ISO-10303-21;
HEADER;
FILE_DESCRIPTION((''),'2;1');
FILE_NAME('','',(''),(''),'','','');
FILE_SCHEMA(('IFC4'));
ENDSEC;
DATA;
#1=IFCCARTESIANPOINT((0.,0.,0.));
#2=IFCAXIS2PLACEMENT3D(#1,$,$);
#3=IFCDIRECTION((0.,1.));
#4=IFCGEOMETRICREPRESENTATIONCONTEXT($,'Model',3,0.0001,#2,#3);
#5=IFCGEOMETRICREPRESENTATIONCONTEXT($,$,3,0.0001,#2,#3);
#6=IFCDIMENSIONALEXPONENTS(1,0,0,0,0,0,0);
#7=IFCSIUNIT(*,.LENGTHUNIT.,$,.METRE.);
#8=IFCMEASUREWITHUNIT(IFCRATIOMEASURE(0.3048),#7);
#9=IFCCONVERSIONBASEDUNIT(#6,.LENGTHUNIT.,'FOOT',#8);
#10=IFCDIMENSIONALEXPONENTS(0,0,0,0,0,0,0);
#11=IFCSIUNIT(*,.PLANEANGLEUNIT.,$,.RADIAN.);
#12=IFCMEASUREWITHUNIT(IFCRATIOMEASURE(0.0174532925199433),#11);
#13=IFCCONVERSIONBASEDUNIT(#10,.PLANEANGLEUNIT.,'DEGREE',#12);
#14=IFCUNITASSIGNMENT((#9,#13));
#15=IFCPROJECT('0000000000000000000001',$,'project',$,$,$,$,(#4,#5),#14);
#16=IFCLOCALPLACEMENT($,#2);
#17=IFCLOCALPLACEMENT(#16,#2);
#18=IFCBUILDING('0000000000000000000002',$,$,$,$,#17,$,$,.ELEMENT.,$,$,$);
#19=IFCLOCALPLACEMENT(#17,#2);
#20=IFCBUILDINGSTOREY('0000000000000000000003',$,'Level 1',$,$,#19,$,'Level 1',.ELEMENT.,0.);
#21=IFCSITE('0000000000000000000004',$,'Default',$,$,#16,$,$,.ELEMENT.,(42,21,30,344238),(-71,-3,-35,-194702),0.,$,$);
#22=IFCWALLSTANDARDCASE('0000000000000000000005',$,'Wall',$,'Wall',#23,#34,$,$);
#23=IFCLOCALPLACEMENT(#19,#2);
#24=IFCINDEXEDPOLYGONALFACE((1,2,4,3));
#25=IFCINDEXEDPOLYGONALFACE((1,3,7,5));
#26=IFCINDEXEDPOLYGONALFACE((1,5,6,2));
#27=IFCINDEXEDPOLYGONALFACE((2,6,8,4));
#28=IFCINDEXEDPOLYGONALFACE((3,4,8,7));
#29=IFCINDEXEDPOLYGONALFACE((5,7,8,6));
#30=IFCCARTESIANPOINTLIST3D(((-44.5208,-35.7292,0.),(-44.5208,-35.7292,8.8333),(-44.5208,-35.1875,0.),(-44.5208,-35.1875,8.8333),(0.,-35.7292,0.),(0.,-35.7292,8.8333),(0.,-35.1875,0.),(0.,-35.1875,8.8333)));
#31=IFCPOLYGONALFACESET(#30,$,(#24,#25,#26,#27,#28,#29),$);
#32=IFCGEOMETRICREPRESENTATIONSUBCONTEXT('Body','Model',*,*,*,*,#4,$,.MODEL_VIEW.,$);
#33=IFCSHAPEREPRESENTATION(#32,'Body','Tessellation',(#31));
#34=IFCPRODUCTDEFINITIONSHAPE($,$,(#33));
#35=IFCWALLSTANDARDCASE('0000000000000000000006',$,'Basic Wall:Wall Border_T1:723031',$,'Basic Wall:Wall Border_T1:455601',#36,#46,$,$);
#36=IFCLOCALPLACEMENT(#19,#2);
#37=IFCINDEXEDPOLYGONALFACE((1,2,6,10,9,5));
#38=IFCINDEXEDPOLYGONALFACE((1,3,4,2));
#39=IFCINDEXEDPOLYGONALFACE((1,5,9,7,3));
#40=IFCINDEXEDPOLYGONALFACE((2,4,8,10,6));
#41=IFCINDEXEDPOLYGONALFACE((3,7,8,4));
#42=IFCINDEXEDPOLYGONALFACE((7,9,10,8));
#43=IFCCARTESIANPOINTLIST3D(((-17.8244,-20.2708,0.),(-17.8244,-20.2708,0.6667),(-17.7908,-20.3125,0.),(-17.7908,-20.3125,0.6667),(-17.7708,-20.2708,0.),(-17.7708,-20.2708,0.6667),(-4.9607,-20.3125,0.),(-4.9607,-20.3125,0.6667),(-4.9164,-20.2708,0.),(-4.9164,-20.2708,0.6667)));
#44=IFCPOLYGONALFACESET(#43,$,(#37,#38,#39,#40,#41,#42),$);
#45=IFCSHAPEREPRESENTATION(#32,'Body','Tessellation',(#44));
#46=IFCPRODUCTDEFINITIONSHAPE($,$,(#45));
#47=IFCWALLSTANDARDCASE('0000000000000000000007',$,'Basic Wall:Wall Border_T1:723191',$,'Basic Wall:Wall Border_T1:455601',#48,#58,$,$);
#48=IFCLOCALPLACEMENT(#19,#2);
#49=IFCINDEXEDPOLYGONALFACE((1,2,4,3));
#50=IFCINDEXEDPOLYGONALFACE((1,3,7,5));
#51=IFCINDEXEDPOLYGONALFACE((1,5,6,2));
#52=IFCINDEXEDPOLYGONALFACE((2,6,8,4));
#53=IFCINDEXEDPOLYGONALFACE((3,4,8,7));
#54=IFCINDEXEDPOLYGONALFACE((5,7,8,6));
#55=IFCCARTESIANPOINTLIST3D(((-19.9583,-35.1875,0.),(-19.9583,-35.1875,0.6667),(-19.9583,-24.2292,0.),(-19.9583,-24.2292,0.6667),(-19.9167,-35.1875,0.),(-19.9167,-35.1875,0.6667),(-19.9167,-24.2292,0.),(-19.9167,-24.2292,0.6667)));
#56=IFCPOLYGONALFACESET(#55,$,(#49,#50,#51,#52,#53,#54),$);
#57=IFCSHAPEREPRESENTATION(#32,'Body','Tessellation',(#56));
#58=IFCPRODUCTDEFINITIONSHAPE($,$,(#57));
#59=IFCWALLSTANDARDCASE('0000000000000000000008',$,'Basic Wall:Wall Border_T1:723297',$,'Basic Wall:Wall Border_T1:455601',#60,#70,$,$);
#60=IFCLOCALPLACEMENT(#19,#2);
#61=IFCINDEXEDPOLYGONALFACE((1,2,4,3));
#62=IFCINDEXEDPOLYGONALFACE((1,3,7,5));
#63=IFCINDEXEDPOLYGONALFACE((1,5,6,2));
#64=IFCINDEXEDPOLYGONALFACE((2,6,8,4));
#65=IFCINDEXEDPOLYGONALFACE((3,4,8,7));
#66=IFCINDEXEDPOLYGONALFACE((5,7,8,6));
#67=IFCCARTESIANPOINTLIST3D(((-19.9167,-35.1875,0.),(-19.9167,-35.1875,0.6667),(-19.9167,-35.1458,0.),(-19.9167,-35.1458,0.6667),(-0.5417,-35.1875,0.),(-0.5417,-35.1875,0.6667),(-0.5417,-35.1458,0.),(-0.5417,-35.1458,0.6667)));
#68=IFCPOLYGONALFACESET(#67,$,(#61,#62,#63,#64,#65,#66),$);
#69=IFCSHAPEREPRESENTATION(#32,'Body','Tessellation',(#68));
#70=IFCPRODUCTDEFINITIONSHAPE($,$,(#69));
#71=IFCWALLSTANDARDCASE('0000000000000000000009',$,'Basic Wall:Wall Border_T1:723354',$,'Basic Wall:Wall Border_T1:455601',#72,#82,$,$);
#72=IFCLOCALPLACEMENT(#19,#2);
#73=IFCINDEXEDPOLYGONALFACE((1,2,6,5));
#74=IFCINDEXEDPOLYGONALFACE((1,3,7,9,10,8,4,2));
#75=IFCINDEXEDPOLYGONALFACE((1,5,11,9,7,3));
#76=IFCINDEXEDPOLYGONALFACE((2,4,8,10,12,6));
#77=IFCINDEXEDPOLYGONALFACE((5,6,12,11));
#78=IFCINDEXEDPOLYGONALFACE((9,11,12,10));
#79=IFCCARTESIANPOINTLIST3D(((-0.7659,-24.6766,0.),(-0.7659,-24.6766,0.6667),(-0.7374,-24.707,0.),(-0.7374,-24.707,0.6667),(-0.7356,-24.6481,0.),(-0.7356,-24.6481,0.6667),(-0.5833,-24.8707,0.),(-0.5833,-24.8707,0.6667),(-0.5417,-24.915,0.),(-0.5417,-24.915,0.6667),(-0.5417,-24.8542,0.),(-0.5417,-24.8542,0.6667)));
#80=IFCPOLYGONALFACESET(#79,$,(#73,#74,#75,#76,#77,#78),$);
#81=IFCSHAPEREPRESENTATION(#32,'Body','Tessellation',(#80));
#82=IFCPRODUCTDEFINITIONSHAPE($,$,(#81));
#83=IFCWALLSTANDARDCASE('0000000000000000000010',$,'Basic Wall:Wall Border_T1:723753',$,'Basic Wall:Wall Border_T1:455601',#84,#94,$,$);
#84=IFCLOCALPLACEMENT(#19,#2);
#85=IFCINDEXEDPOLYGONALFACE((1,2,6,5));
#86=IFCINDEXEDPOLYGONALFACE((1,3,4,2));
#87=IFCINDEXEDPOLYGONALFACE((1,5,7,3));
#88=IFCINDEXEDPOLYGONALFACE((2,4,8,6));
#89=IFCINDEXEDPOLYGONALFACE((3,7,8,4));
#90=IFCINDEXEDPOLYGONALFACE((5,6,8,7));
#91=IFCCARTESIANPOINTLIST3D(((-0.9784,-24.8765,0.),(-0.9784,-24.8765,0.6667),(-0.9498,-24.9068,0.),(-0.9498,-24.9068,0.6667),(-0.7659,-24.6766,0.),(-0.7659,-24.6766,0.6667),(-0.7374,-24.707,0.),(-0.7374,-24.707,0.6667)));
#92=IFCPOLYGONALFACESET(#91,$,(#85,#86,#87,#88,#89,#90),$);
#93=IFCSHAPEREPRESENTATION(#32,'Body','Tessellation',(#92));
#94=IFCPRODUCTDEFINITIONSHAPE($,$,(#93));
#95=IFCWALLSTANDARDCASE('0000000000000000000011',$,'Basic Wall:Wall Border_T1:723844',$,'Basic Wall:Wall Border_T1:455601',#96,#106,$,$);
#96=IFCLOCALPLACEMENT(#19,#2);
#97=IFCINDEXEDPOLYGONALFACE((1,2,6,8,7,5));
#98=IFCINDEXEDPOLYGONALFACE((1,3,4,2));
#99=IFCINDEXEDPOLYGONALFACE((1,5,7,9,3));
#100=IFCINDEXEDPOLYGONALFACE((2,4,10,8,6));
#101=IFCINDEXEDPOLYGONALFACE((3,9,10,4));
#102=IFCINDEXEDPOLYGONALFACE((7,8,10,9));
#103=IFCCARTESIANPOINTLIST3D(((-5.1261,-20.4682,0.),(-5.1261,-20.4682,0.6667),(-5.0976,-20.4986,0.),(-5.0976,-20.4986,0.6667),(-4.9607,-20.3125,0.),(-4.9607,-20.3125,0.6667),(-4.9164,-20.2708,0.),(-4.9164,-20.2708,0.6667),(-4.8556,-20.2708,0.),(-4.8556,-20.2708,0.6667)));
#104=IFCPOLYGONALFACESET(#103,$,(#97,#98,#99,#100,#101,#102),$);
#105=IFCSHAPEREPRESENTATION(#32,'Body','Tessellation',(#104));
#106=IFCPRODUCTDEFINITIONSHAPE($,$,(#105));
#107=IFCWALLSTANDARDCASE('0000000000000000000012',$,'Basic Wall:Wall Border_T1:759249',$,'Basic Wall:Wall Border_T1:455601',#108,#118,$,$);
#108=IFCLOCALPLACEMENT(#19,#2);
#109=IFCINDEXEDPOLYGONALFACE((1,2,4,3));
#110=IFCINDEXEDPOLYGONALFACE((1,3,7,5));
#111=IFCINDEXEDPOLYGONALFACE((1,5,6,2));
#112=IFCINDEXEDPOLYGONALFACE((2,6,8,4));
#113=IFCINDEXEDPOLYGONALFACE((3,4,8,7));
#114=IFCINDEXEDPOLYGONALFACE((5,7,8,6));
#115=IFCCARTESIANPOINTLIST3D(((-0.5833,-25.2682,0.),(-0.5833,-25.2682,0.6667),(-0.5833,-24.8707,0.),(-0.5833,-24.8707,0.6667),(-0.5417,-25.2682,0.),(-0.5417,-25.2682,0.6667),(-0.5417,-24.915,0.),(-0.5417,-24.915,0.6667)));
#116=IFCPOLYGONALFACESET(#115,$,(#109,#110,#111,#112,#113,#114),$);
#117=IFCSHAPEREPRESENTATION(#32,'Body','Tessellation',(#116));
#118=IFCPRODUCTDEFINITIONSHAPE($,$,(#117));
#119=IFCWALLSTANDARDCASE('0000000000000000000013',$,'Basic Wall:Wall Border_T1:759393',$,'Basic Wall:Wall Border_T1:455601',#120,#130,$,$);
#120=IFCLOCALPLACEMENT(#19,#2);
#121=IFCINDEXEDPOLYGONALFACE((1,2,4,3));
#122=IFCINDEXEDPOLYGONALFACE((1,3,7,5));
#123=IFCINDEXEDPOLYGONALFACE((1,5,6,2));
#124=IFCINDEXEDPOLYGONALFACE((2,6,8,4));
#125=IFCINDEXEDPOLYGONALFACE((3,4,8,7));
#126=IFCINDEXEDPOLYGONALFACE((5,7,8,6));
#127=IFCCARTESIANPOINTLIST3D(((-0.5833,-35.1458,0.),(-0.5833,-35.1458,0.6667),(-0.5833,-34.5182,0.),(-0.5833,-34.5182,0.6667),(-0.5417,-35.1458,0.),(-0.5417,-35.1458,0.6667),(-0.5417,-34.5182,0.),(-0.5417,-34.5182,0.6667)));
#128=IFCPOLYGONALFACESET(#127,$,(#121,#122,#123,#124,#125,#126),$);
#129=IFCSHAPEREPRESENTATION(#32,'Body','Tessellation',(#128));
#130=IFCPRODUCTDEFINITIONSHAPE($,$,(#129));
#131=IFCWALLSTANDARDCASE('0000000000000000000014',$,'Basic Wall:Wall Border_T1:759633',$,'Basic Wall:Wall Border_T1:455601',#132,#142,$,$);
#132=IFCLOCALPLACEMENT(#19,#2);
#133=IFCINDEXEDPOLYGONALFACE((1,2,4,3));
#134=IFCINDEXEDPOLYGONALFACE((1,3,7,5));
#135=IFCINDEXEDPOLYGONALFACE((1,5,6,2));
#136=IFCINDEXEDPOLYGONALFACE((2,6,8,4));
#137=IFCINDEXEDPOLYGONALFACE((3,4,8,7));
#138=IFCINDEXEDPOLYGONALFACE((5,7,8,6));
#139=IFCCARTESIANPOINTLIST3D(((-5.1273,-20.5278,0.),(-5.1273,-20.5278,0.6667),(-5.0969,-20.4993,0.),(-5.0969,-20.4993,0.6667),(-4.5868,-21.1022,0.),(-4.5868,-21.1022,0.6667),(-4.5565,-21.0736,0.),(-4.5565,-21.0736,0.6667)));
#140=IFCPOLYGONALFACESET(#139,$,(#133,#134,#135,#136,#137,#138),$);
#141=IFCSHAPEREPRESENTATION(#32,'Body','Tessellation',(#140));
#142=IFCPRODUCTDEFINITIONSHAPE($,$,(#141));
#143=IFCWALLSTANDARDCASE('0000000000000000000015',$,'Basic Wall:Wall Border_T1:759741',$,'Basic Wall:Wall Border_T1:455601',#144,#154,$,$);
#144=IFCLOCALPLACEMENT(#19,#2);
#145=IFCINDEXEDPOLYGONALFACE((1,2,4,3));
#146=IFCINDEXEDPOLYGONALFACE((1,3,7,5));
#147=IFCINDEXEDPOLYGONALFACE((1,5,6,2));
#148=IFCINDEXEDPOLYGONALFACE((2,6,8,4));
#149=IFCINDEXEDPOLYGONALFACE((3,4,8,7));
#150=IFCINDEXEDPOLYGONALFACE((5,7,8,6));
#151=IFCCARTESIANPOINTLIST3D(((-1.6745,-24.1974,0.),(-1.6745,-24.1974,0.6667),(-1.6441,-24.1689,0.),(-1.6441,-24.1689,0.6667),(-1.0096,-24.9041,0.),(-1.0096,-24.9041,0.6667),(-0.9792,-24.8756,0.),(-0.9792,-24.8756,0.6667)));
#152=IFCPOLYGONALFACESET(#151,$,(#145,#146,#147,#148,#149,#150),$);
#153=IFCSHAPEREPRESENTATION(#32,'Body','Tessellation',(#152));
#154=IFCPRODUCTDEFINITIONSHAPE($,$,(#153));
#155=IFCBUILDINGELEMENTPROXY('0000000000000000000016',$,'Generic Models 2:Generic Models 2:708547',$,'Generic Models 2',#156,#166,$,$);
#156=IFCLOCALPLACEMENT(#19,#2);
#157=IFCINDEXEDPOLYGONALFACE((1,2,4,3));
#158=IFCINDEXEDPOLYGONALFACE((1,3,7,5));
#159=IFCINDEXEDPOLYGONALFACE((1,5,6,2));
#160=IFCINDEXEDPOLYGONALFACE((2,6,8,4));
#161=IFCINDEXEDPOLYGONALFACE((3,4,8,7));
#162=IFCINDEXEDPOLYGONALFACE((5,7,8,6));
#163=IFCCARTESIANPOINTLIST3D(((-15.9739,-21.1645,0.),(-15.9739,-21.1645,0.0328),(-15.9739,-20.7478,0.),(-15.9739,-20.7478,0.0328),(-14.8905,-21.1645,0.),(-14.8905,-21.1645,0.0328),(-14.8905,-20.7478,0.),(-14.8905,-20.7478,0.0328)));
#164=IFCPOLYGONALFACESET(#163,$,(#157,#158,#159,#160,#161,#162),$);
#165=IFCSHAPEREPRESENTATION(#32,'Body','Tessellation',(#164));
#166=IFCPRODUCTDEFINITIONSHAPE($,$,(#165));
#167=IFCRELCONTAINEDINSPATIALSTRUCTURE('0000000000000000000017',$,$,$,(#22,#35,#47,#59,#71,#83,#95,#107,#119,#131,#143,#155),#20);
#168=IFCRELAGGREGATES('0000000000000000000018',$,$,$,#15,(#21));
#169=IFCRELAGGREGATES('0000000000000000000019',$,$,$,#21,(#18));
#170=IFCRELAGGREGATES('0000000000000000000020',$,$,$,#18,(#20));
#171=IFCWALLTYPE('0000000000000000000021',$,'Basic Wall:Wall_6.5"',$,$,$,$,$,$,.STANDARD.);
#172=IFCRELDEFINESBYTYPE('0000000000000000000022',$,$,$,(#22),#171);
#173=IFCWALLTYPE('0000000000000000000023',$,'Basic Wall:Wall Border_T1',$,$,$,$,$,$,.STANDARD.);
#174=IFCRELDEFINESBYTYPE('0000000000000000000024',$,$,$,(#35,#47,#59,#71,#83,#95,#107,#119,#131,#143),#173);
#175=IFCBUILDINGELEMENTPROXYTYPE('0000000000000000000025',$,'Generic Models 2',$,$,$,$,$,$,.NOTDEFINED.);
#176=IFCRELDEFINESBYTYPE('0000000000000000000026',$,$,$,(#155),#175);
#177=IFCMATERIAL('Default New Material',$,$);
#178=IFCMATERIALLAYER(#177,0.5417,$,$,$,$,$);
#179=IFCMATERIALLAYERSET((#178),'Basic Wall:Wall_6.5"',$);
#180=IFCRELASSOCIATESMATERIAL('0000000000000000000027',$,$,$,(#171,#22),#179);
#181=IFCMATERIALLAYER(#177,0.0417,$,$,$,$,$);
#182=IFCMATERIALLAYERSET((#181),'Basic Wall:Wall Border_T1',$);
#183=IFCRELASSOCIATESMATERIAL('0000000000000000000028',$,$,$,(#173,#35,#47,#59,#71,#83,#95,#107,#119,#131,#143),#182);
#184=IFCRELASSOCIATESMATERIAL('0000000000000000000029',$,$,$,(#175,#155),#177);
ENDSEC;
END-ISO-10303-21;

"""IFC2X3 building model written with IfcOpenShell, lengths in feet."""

from ifc_helpers import new_model, entity, si_unit, converted_unit, direction, frame, frame_2d, origin, place, context, subcontext, project, spatial, polyline, rectangle, outline, extrude, source, transform, mapped, material, layer, layer_set, layer_usage, type_object, type_shapes, element, save


model = new_model("IFC2X3")

# Units and contexts
model_context = context("Model", 3, precision=0.0001, world=origin(), true_north=direction((0.0, 1.0)))
context_of_model = context(None, 3, precision=0.0001, world=origin(), true_north=direction((0.0, 1.0)))
body_context = subcontext(model_context, "Body", "Model", "MODEL_VIEW")
ifc_project = project(units=[converted_unit("LENGTHUNIT", "FOOT", entity("IfcRatioMeasure", 0.3048), si_unit("LENGTHUNIT", "METRE"), dimensions=[1, 0, 0, 0, 0, 0, 0]), converted_unit("PLANEANGLEUNIT", "DEGREE", entity("IfcRatioMeasure", 0.0174532925199433), si_unit("PLANEANGLEUNIT", "RADIAN"), dimensions=[0, 0, 0, 0, 0, 0, 0])], contexts=[model_context, context_of_model])

# Site, building, storey
site_placement = place(None, origin())
site = spatial("IfcSite", under=ifc_project, at=site_placement, Name="Default", CompositionType="ELEMENT", RefLatitude=(42, 21, 30, 344238), RefLongitude=(-71, -3, -35, -194702), RefElevation=0.0)
building_placement = place(site_placement, origin())
building = spatial("IfcBuilding", under=site, at=building_placement, CompositionType="ELEMENT")
storey_placement = place(building_placement, origin())
storey = spatial("IfcBuildingStorey", under=building, at=storey_placement, Name="Level 1", LongName="Level 1", CompositionType="ELEMENT", Elevation=0.0)

# Wall
ifc_material_1 = material(Name="Default New Material")
ifc_layer_1 = layer(ifc_material_1, 0.5417)
ifc_layer_set_1 = layer_set([ifc_layer_1], Name="Basic Wall:Wall_6.5\"")
ifc_layer_usage_1 = layer_usage(ifc_layer_set_1, "AXIS2", "NEGATIVE", 0.2708)
wall_type_1 = type_object("IfcWallType", Name="Basic Wall:Wall_6.5\"", PredefinedType="STANDARD", material=ifc_layer_set_1)
wall_1_placement = place(storey_placement, frame((0.0, -35.4583, 0.0), z_axis=(0.0, 0.0, 1.0), x_axis=(-1.0, 0.0, 0.0)))
element("IfcWallStandardCase", 1, at=wall_1_placement, inside=storey, type_object=wall_type_1, material=ifc_layer_usage_1, Name="Wall", ObjectType="Wall", context=body_context, shape_type="SweptSolid", body=[
    extrude(rectangle(XDim=44.5208, YDim=0.5417, at=frame_2d((22.2604, 0.0), x_axis=(-1.0, 0.0))), origin(), (0.0, 0.0, 1.0), 8.8333),
])

# Walls
ifc_layer_2 = layer(ifc_material_1, 0.0417)
ifc_layer_set_2 = layer_set([ifc_layer_2], Name="Basic Wall:Wall Border_T1")
ifc_layer_usage_2 = layer_usage(ifc_layer_set_2, "AXIS2", "NEGATIVE", 0.0208)
wall_type_2 = type_object("IfcWallType", Name="Basic Wall:Wall Border_T1", PredefinedType="STANDARD", material=ifc_layer_set_2)
wall_2_placement = place(storey_placement, frame((-4.9164, -20.2917, 0.0), z_axis=(0.0, 0.0, 1.0), x_axis=(-1.0, 0.0, 0.0)))
element("IfcWallStandardCase", 2, at=wall_2_placement, inside=storey, type_object=wall_type_2, material=ifc_layer_usage_2, Name="Basic Wall:Wall Border_T1:723031", ObjectType="Basic Wall:Wall Border_T1:455601", context=body_context, shape_type="SweptSolid", body=[
    extrude(outline(polyline([(12.908, -0.0208), (12.8744, 0.0208), (0.0443, 0.0208), (0.0, -0.0208), (12.8545, -0.0208), (12.908, -0.0208)])), origin(), (0.0, 0.0, 1.0), 0.6667),
])
ifc_layer_usage_3 = layer_usage(ifc_layer_set_2, "AXIS2", "NEGATIVE", 0.0208)
wall_3_placement = place(storey_placement, frame((-19.9375, -24.2292, 0.0), z_axis=(0.0, 0.0, 1.0), x_axis=(0.0, -1.0, 0.0)))
element("IfcWallStandardCase", 3, at=wall_3_placement, inside=storey, type_object=wall_type_2, material=ifc_layer_usage_3, Name="Basic Wall:Wall Border_T1:723191", ObjectType="Basic Wall:Wall Border_T1:455601", context=body_context, shape_type="SweptSolid", body=[
    extrude(rectangle(XDim=10.9583, YDim=0.0417, at=frame_2d((5.4792, 0.0), x_axis=(-1.0, 0.0))), origin(), (0.0, 0.0, 1.0), 0.6667),
])
ifc_layer_usage_4 = layer_usage(ifc_layer_set_2, "AXIS2", "NEGATIVE", 0.0208)
wall_4_placement = place(storey_placement, frame((-19.9167, -35.1667, 0.0)))
element("IfcWallStandardCase", 4, at=wall_4_placement, inside=storey, type_object=wall_type_2, material=ifc_layer_usage_4, Name="Basic Wall:Wall Border_T1:723297", ObjectType="Basic Wall:Wall Border_T1:455601", context=body_context, shape_type="SweptSolid", body=[
    extrude(rectangle(XDim=19.375, YDim=0.0417, at=frame_2d((9.6875, 0.0), x_axis=(-1.0, 0.0))), origin(), (0.0, 0.0, 1.0), 0.6667),
])
ifc_layer_usage_5 = layer_usage(ifc_layer_set_2, "AXIS2", "POSITIVE", -0.0208)
wall_5_placement = place(storey_placement, frame((-0.7508, -24.6623, 0.0), z_axis=(0.0, 0.0, 1.0), x_axis=(0.685261, -0.728297, 0.0)))
element("IfcWallStandardCase", 5, at=wall_5_placement, inside=storey, type_object=wall_type_2, material=ifc_layer_usage_5, Name="Basic Wall:Wall Border_T1:723354", ObjectType="Basic Wall:Wall Border_T1:455601", context=body_context, shape_type="SweptSolid", body=[
    extrude(outline(polyline([(0.3273, -0.0208), (0.283, 0.0208), (0.0, 0.0208), (0.0, -0.0208), (0.0417, -0.0208), (0.2665, -0.0208), (0.3273, -0.0208)])), origin(), (0.0, 0.0, 1.0), 0.6667),
])
ifc_layer_usage_6 = layer_usage(ifc_layer_set_2, "AXIS2", "NEGATIVE", 0.0208)
wall_6_placement = place(storey_placement, frame((-0.7517, -24.6918, 0.0), z_axis=(0.0, 0.0, 1.0), x_axis=(-0.728297, -0.685261, 0.0)))
element("IfcWallStandardCase", 6, at=wall_6_placement, inside=storey, type_object=wall_type_2, material=ifc_layer_usage_6, Name="Basic Wall:Wall Border_T1:723753", ObjectType="Basic Wall:Wall Border_T1:455601", context=body_context, shape_type="SweptSolid", body=[
    extrude(rectangle(XDim=0.2917, YDim=0.0417, at=frame_2d((0.1458, 0.0), x_axis=(-1.0, 0.0))), origin(), (0.0, 0.0, 1.0), 0.6667),
])
ifc_layer_usage_7 = layer_usage(ifc_layer_set_2, "AXIS2", "NEGATIVE", 0.0208)
wall_7_placement = place(storey_placement, frame((-5.1119, -20.4834, 0.0), z_axis=(0.0, 0.0, 1.0), x_axis=(0.728297, 0.685261, 0.0)))
element("IfcWallStandardCase", 7, at=wall_7_placement, inside=storey, type_object=wall_type_2, material=ifc_layer_usage_7, Name="Basic Wall:Wall Border_T1:723844", ObjectType="Basic Wall:Wall Border_T1:455601", context=body_context, shape_type="SweptSolid", body=[
    extrude(outline(polyline([(0.3323, -0.0208), (0.288, 0.0208), (0.2272, 0.0208), (0.0, 0.0208), (0.0, -0.0208), (0.3323, -0.0208)])), origin(), (0.0, 0.0, 1.0), 0.6667),
])
ifc_layer_usage_8 = layer_usage(ifc_layer_set_2, "AXIS2", "POSITIVE", -0.0208)
wall_8_placement = place(storey_placement, frame((-0.5625, -24.8707, 0.0), z_axis=(0.0, 0.0, 1.0), x_axis=(0.0, -1.0, 0.0)))
element("IfcWallStandardCase", 8, at=wall_8_placement, inside=storey, type_object=wall_type_2, material=ifc_layer_usage_8, Name="Basic Wall:Wall Border_T1:759249", ObjectType="Basic Wall:Wall Border_T1:455601", context=body_context, shape_type="SweptSolid", body=[
    extrude(outline(polyline([(0.3975, -0.0208), (0.3975, 0.0208), (0.0443, 0.0208), (0.0, -0.0208), (0.3975, -0.0208)])), origin(), (0.0, 0.0, 1.0), 0.6667),
])
ifc_layer_usage_9 = layer_usage(ifc_layer_set_2, "AXIS2", "POSITIVE", -0.0208)
wall_9_placement = place(storey_placement, frame((-0.5625, -34.5182, 0.0), z_axis=(0.0, 0.0, 1.0), x_axis=(0.0, -1.0, 0.0)))
element("IfcWallStandardCase", 9, at=wall_9_placement, inside=storey, type_object=wall_type_2, material=ifc_layer_usage_9, Name="Basic Wall:Wall Border_T1:759393", ObjectType="Basic Wall:Wall Border_T1:455601", context=body_context, shape_type="SweptSolid", body=[
    extrude(rectangle(XDim=0.6276, YDim=0.0417, at=frame_2d((0.3138, 0.0), x_axis=(-1.0, 0.0))), origin(), (0.0, 0.0, 1.0), 0.6667),
])
ifc_layer_usage_10 = layer_usage(ifc_layer_set_2, "AXIS2", "POSITIVE", -0.0208)
wall_10_placement = place(storey_placement, frame((-5.1121, -20.5135, 0.0), z_axis=(0.0, 0.0, 1.0), x_axis=(0.685261, -0.728297, 0.0)))
element("IfcWallStandardCase", 10, at=wall_10_placement, inside=storey, type_object=wall_type_2, material=ifc_layer_usage_10, Name="Basic Wall:Wall Border_T1:759633", ObjectType="Basic Wall:Wall Border_T1:455601", context=body_context, shape_type="SweptSolid", body=[
    extrude(rectangle(XDim=0.7886, YDim=0.0417, at=frame_2d((0.3943, 0.0), x_axis=(-1.0, 0.0))), origin(), (0.0, 0.0, 1.0), 0.6667),
])
ifc_layer_usage_11 = layer_usage(ifc_layer_set_2, "AXIS2", "POSITIVE", -0.0208)
wall_11_placement = place(storey_placement, frame((-1.6593, -24.1832, 0.0), z_axis=(0.0, 0.0, 1.0), x_axis=(0.685261, -0.728297, 0.0)))
element("IfcWallStandardCase", 11, at=wall_11_placement, inside=storey, type_object=wall_type_2, material=ifc_layer_usage_11, Name="Basic Wall:Wall Border_T1:759741", ObjectType="Basic Wall:Wall Border_T1:455601", context=body_context, shape_type="SweptSolid", body=[
    extrude(rectangle(XDim=0.9703, YDim=0.0417, at=frame_2d((0.4852, 0.0), x_axis=(-1.0, 0.0))), origin(), (0.0, 0.0, 1.0), 0.6667),
])

# Building element proxy
building_element_proxy_type_1 = type_object("IfcBuildingElementProxyType", Name="Generic Models 2", PredefinedType="NOTDEFINED", material=ifc_material_1)
shared_shape_1 = source(origin(), body_context, "Body", "SweptSolid", [
    extrude(rectangle(XDim=1.0833, YDim=0.4167, at=frame_2d((0.0, 0.0), x_axis=(1.0, 0.0))), frame((0.5417, 0.2083, 0.0), z_axis=(0.0, 0.0, 1.0), x_axis=(-1.0, 0.0, 0.0)), (0.0, 0.0, 1.0), 0.0328),
])
type_shapes(building_element_proxy_type_1, [shared_shape_1])
proxy_1_placement = place(storey_placement, frame((-15.9739, -21.1645, 0.0)))
element("IfcBuildingElementProxy", 12, at=proxy_1_placement, inside=storey, type_object=building_element_proxy_type_1, material=ifc_material_1, Name="Generic Models 2:Generic Models 2:708547", ObjectType="Generic Models 2", context=body_context, shape_type="MappedRepresentation", body=[
    mapped(shared_shape_1, transform((0.0, 0.0, 0.0), scale=1.0)),
])

save(model, "model.ifc")
